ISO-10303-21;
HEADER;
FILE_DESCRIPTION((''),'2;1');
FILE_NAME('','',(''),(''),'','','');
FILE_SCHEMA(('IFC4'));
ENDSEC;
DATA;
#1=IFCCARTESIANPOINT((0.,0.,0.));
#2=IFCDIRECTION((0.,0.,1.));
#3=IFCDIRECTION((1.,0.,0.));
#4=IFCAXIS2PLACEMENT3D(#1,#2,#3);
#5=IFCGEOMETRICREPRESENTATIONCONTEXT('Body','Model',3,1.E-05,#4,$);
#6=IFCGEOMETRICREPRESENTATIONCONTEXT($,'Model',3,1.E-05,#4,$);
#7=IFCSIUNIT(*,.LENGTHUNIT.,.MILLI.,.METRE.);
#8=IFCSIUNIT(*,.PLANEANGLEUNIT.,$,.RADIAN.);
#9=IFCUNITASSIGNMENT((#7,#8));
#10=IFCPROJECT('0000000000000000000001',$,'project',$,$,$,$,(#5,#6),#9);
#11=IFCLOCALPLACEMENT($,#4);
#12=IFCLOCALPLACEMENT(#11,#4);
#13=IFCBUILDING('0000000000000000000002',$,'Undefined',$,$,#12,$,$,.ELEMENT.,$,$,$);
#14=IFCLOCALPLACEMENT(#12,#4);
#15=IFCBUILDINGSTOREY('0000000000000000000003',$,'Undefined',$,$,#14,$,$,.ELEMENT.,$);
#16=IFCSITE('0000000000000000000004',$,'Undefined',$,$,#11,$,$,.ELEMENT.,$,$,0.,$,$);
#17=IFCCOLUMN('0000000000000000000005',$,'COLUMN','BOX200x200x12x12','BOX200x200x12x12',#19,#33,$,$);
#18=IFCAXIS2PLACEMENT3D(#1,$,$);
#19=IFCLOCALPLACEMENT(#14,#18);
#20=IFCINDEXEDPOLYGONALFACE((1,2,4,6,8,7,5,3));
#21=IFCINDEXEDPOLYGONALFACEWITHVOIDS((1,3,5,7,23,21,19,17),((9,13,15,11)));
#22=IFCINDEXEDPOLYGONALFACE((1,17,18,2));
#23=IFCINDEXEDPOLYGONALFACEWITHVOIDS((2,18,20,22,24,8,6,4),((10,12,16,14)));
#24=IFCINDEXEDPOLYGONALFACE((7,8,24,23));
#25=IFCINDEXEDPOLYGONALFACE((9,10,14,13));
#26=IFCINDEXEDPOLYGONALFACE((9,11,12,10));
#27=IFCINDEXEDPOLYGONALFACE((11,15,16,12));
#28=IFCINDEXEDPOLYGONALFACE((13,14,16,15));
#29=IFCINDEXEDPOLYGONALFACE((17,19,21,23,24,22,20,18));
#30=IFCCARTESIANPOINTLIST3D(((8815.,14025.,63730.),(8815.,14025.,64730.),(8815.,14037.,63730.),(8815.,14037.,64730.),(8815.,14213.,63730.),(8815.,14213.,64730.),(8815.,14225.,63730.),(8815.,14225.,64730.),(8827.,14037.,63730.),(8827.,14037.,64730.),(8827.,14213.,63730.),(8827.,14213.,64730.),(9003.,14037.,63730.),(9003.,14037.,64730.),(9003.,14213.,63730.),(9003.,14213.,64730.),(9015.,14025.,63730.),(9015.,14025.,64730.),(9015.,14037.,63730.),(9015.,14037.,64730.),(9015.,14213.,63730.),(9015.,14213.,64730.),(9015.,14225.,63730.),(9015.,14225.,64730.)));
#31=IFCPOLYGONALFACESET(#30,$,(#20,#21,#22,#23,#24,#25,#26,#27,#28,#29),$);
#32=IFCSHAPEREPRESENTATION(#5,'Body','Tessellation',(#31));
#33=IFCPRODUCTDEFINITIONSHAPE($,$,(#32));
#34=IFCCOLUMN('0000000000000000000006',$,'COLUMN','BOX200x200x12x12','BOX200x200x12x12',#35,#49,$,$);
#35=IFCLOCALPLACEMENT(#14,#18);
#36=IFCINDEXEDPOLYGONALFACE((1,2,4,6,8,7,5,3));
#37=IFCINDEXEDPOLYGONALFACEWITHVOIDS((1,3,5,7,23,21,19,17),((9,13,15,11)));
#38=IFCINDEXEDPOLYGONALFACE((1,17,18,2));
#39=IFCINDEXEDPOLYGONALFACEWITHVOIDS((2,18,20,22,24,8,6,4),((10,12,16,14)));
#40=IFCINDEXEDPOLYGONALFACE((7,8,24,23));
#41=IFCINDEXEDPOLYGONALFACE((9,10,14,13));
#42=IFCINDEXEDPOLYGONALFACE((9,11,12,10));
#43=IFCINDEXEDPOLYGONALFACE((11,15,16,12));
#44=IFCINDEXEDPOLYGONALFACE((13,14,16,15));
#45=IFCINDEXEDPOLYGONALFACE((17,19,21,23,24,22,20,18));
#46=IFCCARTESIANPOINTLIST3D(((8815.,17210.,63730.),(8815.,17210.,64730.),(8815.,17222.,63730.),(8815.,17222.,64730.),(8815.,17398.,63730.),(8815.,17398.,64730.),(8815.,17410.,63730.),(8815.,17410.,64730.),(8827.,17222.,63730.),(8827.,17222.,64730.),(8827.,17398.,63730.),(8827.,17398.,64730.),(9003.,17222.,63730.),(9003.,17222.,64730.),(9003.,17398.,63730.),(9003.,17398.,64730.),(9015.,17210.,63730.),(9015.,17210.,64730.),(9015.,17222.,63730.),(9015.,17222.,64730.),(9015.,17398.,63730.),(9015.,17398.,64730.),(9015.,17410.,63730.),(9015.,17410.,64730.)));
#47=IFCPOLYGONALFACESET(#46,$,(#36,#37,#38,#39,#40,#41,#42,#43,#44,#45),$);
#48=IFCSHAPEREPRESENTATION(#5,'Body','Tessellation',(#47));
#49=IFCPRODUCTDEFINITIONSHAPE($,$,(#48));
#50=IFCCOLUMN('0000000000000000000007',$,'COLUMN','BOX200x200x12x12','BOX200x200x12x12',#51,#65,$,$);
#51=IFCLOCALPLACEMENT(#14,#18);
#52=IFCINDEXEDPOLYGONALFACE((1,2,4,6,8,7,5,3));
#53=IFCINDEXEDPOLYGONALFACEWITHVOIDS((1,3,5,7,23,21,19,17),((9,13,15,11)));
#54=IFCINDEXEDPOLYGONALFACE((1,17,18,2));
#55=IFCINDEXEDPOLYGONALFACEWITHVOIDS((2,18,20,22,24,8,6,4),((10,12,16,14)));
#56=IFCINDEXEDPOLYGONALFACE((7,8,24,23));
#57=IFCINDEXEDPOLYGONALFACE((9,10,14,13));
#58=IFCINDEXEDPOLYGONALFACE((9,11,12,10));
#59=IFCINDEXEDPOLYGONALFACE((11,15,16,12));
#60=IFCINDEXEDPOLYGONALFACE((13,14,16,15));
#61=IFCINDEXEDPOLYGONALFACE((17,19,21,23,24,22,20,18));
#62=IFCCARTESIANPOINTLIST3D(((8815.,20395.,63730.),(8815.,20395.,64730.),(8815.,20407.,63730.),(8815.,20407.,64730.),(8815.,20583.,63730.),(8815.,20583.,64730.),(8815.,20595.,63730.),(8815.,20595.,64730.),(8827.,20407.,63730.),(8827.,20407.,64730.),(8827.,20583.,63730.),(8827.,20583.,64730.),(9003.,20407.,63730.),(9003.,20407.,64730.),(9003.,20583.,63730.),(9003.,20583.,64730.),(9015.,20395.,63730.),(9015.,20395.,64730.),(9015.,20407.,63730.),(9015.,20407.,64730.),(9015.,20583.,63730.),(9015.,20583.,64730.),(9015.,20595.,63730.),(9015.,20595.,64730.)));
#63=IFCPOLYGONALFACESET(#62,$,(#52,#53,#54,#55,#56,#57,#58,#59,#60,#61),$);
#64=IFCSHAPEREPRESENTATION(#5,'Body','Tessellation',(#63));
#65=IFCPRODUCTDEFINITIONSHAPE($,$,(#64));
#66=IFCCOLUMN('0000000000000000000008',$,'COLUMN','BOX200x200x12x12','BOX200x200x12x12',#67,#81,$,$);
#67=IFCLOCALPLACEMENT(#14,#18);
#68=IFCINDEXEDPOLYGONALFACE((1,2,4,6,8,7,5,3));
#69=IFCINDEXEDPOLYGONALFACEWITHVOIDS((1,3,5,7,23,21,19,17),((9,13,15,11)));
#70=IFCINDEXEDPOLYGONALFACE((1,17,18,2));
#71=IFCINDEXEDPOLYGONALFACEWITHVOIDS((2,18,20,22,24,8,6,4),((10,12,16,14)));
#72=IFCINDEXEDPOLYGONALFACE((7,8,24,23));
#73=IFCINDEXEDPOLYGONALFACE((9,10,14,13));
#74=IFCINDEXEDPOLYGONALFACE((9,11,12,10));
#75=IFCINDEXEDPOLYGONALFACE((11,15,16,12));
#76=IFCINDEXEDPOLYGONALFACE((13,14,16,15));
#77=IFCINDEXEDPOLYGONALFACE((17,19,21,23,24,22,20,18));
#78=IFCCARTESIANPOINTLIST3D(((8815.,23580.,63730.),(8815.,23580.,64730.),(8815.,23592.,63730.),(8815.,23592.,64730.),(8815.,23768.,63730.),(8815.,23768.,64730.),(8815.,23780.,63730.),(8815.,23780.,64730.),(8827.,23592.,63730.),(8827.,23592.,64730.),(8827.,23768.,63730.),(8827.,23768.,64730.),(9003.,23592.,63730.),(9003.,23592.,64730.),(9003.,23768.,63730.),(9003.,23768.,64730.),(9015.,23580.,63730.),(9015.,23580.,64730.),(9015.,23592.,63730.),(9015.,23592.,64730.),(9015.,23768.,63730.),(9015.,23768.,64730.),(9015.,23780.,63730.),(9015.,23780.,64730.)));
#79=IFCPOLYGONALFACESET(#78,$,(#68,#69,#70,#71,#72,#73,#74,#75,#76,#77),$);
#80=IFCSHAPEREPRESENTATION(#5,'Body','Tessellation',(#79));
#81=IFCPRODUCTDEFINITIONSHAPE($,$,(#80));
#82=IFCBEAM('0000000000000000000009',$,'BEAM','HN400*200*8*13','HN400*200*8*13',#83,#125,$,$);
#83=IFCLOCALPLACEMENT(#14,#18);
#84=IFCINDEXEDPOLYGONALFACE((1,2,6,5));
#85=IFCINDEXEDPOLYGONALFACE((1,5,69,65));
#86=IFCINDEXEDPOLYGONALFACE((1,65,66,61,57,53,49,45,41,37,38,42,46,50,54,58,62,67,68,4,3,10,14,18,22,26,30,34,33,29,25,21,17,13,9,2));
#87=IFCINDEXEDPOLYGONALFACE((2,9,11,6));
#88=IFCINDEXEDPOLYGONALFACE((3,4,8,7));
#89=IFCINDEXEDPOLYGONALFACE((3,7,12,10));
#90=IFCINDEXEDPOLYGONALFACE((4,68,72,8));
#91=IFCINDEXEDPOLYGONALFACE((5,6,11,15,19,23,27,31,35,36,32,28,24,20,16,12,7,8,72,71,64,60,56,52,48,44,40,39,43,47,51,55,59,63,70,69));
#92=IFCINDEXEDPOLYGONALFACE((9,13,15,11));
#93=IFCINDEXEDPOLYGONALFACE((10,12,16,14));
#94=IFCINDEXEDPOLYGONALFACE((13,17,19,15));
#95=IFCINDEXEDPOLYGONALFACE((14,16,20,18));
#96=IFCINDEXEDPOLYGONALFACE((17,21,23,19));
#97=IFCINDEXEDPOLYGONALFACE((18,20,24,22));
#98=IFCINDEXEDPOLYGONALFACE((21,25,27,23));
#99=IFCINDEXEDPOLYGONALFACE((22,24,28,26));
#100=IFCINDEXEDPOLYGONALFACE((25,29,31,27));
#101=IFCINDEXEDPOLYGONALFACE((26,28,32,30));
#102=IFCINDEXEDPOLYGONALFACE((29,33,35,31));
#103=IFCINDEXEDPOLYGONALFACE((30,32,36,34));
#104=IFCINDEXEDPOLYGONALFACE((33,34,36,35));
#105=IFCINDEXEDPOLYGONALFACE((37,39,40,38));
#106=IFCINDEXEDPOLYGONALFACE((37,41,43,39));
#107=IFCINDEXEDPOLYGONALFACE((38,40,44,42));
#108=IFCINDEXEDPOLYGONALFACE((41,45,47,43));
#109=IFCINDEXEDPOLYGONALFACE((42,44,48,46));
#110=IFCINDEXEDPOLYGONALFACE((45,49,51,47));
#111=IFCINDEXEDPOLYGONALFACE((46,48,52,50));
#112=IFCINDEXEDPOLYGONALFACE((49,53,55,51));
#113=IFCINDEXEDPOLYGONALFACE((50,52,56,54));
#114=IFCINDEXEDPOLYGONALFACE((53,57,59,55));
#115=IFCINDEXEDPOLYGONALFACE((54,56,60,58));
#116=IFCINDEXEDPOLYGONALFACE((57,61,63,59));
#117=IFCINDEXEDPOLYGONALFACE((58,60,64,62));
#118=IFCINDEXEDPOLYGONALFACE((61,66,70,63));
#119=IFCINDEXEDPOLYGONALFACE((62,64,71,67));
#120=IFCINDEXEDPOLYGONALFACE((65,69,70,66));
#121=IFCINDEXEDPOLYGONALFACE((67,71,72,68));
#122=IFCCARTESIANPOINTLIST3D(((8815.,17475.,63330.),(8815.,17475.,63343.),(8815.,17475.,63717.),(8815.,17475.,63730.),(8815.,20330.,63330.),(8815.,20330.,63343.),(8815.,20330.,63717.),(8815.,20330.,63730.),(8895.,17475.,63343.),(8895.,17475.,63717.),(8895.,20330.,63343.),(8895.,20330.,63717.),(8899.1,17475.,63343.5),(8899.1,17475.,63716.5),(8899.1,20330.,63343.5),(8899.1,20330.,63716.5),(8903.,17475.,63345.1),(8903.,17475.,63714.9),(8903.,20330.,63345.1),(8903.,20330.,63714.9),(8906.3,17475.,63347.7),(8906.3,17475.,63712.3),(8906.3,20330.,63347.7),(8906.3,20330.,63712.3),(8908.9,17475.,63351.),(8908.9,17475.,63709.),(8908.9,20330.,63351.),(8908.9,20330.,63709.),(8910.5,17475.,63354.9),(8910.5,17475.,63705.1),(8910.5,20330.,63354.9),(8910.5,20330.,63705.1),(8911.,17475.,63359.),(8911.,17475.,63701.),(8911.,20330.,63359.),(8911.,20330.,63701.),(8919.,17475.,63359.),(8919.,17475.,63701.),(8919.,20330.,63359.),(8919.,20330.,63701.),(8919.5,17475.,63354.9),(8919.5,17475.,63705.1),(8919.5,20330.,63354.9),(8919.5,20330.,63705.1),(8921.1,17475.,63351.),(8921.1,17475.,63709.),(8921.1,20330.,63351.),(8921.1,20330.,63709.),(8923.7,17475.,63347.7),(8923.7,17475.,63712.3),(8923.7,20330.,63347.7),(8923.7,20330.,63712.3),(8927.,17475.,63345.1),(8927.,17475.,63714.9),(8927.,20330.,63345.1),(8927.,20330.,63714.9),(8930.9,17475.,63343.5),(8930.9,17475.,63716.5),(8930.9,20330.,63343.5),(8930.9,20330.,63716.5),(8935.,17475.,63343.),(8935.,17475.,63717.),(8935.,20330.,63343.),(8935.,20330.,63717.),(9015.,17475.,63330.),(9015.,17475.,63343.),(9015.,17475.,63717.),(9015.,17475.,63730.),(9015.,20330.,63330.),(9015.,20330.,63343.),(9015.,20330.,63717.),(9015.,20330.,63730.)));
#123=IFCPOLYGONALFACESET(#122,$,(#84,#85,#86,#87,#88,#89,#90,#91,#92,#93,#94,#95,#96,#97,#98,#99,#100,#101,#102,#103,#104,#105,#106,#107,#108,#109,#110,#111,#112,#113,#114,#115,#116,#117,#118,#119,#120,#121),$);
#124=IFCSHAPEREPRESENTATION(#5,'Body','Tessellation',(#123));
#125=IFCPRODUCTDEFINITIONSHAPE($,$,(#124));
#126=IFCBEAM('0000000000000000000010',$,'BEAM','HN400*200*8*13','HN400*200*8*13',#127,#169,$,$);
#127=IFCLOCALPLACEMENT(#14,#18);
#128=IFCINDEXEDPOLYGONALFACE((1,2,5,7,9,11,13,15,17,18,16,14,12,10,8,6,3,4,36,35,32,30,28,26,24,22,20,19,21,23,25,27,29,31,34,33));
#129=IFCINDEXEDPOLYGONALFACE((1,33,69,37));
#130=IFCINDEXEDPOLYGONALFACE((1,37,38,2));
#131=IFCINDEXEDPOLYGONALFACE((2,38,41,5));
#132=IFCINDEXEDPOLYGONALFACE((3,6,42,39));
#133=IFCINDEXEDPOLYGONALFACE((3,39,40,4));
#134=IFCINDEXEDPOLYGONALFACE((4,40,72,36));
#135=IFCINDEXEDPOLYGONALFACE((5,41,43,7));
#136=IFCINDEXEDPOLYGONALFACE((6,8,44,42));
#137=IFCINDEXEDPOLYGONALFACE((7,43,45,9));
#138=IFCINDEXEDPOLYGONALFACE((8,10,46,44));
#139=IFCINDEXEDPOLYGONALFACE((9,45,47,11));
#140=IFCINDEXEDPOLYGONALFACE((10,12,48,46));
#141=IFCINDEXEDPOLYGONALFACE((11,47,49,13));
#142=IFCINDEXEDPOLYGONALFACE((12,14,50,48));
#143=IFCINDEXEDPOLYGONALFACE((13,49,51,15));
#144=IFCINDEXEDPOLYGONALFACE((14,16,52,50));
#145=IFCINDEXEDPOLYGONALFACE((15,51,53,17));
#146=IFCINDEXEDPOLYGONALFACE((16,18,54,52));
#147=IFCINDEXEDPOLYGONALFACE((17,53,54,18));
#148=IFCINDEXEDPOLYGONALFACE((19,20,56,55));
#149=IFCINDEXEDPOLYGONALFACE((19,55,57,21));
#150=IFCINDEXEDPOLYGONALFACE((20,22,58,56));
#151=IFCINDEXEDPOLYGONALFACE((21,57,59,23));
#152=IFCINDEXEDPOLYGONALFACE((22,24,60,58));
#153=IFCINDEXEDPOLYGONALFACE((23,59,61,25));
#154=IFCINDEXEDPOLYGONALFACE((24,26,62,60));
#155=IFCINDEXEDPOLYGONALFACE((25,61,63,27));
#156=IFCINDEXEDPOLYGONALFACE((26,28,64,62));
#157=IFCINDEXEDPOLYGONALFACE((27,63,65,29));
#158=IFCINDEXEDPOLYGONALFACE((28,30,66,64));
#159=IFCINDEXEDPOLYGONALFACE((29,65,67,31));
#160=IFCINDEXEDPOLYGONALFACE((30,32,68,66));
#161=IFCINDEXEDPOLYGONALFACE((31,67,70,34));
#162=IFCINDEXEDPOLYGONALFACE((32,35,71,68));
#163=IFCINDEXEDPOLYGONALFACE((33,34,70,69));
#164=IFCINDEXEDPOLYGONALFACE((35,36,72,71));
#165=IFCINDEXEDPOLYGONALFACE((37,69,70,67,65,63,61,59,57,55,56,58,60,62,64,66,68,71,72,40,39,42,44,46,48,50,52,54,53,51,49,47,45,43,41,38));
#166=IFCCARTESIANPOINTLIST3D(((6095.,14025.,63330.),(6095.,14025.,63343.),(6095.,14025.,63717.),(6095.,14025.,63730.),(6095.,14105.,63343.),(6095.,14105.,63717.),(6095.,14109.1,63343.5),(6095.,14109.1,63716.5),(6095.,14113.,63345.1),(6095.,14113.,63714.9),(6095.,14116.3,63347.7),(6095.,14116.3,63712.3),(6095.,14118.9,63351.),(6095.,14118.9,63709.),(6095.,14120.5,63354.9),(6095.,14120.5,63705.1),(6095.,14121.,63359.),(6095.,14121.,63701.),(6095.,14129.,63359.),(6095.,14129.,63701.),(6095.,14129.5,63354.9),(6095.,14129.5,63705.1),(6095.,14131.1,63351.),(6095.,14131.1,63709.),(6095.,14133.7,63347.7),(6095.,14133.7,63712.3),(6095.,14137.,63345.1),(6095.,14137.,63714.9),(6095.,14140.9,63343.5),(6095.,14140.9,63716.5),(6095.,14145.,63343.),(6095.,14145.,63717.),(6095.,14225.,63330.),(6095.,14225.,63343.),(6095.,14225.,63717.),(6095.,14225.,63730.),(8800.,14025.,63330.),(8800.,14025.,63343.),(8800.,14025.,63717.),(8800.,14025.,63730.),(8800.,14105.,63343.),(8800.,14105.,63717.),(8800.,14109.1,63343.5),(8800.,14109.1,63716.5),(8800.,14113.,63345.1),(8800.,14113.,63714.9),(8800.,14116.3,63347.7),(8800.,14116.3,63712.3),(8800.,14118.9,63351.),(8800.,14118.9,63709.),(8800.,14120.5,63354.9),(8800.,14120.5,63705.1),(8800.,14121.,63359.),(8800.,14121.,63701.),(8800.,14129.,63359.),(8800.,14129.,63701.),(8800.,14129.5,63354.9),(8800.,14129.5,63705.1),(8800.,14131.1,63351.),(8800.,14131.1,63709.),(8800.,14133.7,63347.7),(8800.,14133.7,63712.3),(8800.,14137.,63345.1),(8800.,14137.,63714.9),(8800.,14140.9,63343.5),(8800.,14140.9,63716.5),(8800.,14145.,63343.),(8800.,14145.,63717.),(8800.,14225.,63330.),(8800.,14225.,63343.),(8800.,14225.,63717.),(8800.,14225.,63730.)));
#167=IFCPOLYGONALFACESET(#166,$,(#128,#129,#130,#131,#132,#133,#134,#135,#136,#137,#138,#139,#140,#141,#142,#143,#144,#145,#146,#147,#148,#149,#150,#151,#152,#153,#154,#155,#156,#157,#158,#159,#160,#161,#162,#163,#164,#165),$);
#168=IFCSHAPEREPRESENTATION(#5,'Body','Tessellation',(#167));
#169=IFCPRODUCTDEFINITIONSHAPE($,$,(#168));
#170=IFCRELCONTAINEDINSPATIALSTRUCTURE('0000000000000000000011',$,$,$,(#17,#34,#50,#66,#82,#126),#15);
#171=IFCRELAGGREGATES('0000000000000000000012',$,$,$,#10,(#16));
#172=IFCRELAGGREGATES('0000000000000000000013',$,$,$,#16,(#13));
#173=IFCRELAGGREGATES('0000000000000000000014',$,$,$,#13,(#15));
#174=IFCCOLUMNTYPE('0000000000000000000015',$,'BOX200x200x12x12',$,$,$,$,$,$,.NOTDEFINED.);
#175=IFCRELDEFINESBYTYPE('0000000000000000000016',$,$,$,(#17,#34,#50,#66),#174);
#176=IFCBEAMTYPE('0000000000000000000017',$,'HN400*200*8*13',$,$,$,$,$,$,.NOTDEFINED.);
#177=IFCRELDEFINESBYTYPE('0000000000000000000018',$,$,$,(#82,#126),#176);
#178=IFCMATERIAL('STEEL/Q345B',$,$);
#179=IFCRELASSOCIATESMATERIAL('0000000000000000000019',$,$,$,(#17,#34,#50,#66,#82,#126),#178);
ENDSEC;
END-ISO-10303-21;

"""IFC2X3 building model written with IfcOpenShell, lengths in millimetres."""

from ifc_helpers import new_model, si_unit, frame, origin_with_axes, origin_2d_with_axis, place, context, project, spatial, polyline, i_section, outline, extrude, material, type_object, element, save


model = new_model("IFC2X3")

# Units and contexts
model_context_1 = context("Model", 3, precision=1e-05, world=origin_with_axes(), identifier="Body")
model_context_2 = context("Model", 3, precision=1e-05, world=origin_with_axes())
ifc_project = project(units=[si_unit("LENGTHUNIT", "METRE", prefix="MILLI"), si_unit("PLANEANGLEUNIT", "RADIAN")], contexts=[model_context_1, model_context_2])

# Site, building, storey
site_placement = place(None, origin_with_axes())
site = spatial("IfcSite", under=ifc_project, at=site_placement, Name="Undefined", CompositionType="ELEMENT", RefElevation=0.0)
building_placement = place(site_placement, origin_with_axes())
building = spatial("IfcBuilding", under=site, at=building_placement, Name="Undefined", CompositionType="ELEMENT")
storey_placement = place(building_placement, origin_with_axes())
storey = spatial("IfcBuildingStorey", under=building, at=storey_placement, Name="Undefined", CompositionType="ELEMENT")

# Columns
ifc_material_1 = material(Name="STEEL/Q345B")
column_type = type_object("IfcColumnType", Name="BOX200x200x12x12", PredefinedType="NOTDEFINED")
column_placement = place(storey_placement, frame((8915.0, 14125.0, 63730.0), z_axis=(0.0, 0.0, 1.0), x_axis=(1.0, 0.0, 0.0)))
element("IfcColumn", 1, at=column_placement, inside=storey, type_object=column_type, material=ifc_material_1, Name="COLUMN", Description="BOX200x200x12x12", ObjectType="BOX200x200x12x12", context=model_context_1, shape_type="SweptSolid", body=[
    extrude(outline(polyline([(-100.0, -100.0), (100.0, -100.0), (100.0, -88.0), (100.0, 88.0), (100.0, 100.0), (-100.0, 100.0), (-100.0, 88.0), (-100.0, -88.0), (-100.0, -100.0)]), holes=[polyline([(-88.0, -88.0), (-88.0, 88.0), (88.0, 88.0), (88.0, -88.0), (-88.0, -88.0)])]), frame((0.0, 0.0, 1000.0), z_axis=(0.0, 0.0, -1.0), x_axis=(-1.0, 0.0, 0.0)), (0.0, 0.0, 1.0), 1000.0),
])
for number, where, z_axis, x_axis, name in (
    (2, (8915.0, 17310.0, 63730.0), (0.0, 0.0, 1.0), (1.0, 0.0, 0.0), "COLUMN"),
    (3, (8915.0, 20495.0, 63730.0), (0.0, 0.0, 1.0), (1.0, 0.0, 0.0), "COLUMN"),
    (4, (8915.0, 23680.0, 63730.0), (0.0, 0.0, 1.0), (1.0, 0.0, 0.0), "COLUMN"),
):
    element("IfcColumn", number, at=place(storey_placement, frame(where, z_axis=z_axis, x_axis=x_axis)), inside=storey, type_object=column_type, material=ifc_material_1, Name=name, Description="BOX200x200x12x12", ObjectType="BOX200x200x12x12", context=model_context_1, shape_type="SweptSolid", body=[
        extrude(outline(polyline([(-100.0, -100.0), (100.0, -100.0), (100.0, -88.0), (100.0, 88.0), (100.0, 100.0), (-100.0, 100.0), (-100.0, 88.0), (-100.0, -88.0), (-100.0, -100.0)]), holes=[polyline([(-88.0, -88.0), (-88.0, 88.0), (88.0, 88.0), (88.0, -88.0), (-88.0, -88.0)])]), frame((0.0, 0.0, 1000.0), z_axis=(0.0, 0.0, -1.0), x_axis=(-1.0, 0.0, 0.0)), (0.0, 0.0, 1.0), 1000.0),
    ])

# Beams
beam_type_1 = type_object("IfcBeamType", Name="HN400*200*8*13", PredefinedType="NOTDEFINED")
beam_1_placement = place(storey_placement, frame((8915.0, 17310.0, 63530.0), z_axis=(0.0, 0.0, 1.0), x_axis=(0.0, 1.0, 0.0)))
element("IfcBeam", 5, at=beam_1_placement, inside=storey, type_object=beam_type_1, material=ifc_material_1, Name="BEAM", Description="HN400*200*8*13", ObjectType="HN400*200*8*13", context=model_context_1, shape_type="SweptSolid", body=[
    extrude(i_section(OverallWidth=200.0, OverallDepth=400.0, WebThickness=8.0, FlangeThickness=13.0, FilletRadius=16.0, at=origin_2d_with_axis()), frame((3020.0, 0.0, 0.0), z_axis=(-1.0, 0.0, 0.0), x_axis=(0.0, -1.0, 0.0)), (0.0, 0.0, 1.0), 2855.0),
])
beam_2_placement = place(storey_placement, frame((8915.0, 14125.0, 63530.0), z_axis=(0.0, 0.0, 1.0), x_axis=(-1.0, 0.0, 0.0)))
element("IfcBeam", 6, at=beam_2_placement, inside=storey, type_object=beam_type_1, material=ifc_material_1, Name="BEAM", Description="HN400*200*8*13", ObjectType="HN400*200*8*13", context=model_context_1, shape_type="SweptSolid", body=[
    extrude(i_section(OverallWidth=200.0, OverallDepth=400.0, WebThickness=8.0, FlangeThickness=13.0, FilletRadius=16.0, at=origin_2d_with_axis()), frame((2820.0, 0.0, 0.0), z_axis=(-1.0, 0.0, 0.0), x_axis=(0.0, -1.0, 0.0)), (0.0, 0.0, 1.0), 2705.0),
])

save(model, "model.ifc")
